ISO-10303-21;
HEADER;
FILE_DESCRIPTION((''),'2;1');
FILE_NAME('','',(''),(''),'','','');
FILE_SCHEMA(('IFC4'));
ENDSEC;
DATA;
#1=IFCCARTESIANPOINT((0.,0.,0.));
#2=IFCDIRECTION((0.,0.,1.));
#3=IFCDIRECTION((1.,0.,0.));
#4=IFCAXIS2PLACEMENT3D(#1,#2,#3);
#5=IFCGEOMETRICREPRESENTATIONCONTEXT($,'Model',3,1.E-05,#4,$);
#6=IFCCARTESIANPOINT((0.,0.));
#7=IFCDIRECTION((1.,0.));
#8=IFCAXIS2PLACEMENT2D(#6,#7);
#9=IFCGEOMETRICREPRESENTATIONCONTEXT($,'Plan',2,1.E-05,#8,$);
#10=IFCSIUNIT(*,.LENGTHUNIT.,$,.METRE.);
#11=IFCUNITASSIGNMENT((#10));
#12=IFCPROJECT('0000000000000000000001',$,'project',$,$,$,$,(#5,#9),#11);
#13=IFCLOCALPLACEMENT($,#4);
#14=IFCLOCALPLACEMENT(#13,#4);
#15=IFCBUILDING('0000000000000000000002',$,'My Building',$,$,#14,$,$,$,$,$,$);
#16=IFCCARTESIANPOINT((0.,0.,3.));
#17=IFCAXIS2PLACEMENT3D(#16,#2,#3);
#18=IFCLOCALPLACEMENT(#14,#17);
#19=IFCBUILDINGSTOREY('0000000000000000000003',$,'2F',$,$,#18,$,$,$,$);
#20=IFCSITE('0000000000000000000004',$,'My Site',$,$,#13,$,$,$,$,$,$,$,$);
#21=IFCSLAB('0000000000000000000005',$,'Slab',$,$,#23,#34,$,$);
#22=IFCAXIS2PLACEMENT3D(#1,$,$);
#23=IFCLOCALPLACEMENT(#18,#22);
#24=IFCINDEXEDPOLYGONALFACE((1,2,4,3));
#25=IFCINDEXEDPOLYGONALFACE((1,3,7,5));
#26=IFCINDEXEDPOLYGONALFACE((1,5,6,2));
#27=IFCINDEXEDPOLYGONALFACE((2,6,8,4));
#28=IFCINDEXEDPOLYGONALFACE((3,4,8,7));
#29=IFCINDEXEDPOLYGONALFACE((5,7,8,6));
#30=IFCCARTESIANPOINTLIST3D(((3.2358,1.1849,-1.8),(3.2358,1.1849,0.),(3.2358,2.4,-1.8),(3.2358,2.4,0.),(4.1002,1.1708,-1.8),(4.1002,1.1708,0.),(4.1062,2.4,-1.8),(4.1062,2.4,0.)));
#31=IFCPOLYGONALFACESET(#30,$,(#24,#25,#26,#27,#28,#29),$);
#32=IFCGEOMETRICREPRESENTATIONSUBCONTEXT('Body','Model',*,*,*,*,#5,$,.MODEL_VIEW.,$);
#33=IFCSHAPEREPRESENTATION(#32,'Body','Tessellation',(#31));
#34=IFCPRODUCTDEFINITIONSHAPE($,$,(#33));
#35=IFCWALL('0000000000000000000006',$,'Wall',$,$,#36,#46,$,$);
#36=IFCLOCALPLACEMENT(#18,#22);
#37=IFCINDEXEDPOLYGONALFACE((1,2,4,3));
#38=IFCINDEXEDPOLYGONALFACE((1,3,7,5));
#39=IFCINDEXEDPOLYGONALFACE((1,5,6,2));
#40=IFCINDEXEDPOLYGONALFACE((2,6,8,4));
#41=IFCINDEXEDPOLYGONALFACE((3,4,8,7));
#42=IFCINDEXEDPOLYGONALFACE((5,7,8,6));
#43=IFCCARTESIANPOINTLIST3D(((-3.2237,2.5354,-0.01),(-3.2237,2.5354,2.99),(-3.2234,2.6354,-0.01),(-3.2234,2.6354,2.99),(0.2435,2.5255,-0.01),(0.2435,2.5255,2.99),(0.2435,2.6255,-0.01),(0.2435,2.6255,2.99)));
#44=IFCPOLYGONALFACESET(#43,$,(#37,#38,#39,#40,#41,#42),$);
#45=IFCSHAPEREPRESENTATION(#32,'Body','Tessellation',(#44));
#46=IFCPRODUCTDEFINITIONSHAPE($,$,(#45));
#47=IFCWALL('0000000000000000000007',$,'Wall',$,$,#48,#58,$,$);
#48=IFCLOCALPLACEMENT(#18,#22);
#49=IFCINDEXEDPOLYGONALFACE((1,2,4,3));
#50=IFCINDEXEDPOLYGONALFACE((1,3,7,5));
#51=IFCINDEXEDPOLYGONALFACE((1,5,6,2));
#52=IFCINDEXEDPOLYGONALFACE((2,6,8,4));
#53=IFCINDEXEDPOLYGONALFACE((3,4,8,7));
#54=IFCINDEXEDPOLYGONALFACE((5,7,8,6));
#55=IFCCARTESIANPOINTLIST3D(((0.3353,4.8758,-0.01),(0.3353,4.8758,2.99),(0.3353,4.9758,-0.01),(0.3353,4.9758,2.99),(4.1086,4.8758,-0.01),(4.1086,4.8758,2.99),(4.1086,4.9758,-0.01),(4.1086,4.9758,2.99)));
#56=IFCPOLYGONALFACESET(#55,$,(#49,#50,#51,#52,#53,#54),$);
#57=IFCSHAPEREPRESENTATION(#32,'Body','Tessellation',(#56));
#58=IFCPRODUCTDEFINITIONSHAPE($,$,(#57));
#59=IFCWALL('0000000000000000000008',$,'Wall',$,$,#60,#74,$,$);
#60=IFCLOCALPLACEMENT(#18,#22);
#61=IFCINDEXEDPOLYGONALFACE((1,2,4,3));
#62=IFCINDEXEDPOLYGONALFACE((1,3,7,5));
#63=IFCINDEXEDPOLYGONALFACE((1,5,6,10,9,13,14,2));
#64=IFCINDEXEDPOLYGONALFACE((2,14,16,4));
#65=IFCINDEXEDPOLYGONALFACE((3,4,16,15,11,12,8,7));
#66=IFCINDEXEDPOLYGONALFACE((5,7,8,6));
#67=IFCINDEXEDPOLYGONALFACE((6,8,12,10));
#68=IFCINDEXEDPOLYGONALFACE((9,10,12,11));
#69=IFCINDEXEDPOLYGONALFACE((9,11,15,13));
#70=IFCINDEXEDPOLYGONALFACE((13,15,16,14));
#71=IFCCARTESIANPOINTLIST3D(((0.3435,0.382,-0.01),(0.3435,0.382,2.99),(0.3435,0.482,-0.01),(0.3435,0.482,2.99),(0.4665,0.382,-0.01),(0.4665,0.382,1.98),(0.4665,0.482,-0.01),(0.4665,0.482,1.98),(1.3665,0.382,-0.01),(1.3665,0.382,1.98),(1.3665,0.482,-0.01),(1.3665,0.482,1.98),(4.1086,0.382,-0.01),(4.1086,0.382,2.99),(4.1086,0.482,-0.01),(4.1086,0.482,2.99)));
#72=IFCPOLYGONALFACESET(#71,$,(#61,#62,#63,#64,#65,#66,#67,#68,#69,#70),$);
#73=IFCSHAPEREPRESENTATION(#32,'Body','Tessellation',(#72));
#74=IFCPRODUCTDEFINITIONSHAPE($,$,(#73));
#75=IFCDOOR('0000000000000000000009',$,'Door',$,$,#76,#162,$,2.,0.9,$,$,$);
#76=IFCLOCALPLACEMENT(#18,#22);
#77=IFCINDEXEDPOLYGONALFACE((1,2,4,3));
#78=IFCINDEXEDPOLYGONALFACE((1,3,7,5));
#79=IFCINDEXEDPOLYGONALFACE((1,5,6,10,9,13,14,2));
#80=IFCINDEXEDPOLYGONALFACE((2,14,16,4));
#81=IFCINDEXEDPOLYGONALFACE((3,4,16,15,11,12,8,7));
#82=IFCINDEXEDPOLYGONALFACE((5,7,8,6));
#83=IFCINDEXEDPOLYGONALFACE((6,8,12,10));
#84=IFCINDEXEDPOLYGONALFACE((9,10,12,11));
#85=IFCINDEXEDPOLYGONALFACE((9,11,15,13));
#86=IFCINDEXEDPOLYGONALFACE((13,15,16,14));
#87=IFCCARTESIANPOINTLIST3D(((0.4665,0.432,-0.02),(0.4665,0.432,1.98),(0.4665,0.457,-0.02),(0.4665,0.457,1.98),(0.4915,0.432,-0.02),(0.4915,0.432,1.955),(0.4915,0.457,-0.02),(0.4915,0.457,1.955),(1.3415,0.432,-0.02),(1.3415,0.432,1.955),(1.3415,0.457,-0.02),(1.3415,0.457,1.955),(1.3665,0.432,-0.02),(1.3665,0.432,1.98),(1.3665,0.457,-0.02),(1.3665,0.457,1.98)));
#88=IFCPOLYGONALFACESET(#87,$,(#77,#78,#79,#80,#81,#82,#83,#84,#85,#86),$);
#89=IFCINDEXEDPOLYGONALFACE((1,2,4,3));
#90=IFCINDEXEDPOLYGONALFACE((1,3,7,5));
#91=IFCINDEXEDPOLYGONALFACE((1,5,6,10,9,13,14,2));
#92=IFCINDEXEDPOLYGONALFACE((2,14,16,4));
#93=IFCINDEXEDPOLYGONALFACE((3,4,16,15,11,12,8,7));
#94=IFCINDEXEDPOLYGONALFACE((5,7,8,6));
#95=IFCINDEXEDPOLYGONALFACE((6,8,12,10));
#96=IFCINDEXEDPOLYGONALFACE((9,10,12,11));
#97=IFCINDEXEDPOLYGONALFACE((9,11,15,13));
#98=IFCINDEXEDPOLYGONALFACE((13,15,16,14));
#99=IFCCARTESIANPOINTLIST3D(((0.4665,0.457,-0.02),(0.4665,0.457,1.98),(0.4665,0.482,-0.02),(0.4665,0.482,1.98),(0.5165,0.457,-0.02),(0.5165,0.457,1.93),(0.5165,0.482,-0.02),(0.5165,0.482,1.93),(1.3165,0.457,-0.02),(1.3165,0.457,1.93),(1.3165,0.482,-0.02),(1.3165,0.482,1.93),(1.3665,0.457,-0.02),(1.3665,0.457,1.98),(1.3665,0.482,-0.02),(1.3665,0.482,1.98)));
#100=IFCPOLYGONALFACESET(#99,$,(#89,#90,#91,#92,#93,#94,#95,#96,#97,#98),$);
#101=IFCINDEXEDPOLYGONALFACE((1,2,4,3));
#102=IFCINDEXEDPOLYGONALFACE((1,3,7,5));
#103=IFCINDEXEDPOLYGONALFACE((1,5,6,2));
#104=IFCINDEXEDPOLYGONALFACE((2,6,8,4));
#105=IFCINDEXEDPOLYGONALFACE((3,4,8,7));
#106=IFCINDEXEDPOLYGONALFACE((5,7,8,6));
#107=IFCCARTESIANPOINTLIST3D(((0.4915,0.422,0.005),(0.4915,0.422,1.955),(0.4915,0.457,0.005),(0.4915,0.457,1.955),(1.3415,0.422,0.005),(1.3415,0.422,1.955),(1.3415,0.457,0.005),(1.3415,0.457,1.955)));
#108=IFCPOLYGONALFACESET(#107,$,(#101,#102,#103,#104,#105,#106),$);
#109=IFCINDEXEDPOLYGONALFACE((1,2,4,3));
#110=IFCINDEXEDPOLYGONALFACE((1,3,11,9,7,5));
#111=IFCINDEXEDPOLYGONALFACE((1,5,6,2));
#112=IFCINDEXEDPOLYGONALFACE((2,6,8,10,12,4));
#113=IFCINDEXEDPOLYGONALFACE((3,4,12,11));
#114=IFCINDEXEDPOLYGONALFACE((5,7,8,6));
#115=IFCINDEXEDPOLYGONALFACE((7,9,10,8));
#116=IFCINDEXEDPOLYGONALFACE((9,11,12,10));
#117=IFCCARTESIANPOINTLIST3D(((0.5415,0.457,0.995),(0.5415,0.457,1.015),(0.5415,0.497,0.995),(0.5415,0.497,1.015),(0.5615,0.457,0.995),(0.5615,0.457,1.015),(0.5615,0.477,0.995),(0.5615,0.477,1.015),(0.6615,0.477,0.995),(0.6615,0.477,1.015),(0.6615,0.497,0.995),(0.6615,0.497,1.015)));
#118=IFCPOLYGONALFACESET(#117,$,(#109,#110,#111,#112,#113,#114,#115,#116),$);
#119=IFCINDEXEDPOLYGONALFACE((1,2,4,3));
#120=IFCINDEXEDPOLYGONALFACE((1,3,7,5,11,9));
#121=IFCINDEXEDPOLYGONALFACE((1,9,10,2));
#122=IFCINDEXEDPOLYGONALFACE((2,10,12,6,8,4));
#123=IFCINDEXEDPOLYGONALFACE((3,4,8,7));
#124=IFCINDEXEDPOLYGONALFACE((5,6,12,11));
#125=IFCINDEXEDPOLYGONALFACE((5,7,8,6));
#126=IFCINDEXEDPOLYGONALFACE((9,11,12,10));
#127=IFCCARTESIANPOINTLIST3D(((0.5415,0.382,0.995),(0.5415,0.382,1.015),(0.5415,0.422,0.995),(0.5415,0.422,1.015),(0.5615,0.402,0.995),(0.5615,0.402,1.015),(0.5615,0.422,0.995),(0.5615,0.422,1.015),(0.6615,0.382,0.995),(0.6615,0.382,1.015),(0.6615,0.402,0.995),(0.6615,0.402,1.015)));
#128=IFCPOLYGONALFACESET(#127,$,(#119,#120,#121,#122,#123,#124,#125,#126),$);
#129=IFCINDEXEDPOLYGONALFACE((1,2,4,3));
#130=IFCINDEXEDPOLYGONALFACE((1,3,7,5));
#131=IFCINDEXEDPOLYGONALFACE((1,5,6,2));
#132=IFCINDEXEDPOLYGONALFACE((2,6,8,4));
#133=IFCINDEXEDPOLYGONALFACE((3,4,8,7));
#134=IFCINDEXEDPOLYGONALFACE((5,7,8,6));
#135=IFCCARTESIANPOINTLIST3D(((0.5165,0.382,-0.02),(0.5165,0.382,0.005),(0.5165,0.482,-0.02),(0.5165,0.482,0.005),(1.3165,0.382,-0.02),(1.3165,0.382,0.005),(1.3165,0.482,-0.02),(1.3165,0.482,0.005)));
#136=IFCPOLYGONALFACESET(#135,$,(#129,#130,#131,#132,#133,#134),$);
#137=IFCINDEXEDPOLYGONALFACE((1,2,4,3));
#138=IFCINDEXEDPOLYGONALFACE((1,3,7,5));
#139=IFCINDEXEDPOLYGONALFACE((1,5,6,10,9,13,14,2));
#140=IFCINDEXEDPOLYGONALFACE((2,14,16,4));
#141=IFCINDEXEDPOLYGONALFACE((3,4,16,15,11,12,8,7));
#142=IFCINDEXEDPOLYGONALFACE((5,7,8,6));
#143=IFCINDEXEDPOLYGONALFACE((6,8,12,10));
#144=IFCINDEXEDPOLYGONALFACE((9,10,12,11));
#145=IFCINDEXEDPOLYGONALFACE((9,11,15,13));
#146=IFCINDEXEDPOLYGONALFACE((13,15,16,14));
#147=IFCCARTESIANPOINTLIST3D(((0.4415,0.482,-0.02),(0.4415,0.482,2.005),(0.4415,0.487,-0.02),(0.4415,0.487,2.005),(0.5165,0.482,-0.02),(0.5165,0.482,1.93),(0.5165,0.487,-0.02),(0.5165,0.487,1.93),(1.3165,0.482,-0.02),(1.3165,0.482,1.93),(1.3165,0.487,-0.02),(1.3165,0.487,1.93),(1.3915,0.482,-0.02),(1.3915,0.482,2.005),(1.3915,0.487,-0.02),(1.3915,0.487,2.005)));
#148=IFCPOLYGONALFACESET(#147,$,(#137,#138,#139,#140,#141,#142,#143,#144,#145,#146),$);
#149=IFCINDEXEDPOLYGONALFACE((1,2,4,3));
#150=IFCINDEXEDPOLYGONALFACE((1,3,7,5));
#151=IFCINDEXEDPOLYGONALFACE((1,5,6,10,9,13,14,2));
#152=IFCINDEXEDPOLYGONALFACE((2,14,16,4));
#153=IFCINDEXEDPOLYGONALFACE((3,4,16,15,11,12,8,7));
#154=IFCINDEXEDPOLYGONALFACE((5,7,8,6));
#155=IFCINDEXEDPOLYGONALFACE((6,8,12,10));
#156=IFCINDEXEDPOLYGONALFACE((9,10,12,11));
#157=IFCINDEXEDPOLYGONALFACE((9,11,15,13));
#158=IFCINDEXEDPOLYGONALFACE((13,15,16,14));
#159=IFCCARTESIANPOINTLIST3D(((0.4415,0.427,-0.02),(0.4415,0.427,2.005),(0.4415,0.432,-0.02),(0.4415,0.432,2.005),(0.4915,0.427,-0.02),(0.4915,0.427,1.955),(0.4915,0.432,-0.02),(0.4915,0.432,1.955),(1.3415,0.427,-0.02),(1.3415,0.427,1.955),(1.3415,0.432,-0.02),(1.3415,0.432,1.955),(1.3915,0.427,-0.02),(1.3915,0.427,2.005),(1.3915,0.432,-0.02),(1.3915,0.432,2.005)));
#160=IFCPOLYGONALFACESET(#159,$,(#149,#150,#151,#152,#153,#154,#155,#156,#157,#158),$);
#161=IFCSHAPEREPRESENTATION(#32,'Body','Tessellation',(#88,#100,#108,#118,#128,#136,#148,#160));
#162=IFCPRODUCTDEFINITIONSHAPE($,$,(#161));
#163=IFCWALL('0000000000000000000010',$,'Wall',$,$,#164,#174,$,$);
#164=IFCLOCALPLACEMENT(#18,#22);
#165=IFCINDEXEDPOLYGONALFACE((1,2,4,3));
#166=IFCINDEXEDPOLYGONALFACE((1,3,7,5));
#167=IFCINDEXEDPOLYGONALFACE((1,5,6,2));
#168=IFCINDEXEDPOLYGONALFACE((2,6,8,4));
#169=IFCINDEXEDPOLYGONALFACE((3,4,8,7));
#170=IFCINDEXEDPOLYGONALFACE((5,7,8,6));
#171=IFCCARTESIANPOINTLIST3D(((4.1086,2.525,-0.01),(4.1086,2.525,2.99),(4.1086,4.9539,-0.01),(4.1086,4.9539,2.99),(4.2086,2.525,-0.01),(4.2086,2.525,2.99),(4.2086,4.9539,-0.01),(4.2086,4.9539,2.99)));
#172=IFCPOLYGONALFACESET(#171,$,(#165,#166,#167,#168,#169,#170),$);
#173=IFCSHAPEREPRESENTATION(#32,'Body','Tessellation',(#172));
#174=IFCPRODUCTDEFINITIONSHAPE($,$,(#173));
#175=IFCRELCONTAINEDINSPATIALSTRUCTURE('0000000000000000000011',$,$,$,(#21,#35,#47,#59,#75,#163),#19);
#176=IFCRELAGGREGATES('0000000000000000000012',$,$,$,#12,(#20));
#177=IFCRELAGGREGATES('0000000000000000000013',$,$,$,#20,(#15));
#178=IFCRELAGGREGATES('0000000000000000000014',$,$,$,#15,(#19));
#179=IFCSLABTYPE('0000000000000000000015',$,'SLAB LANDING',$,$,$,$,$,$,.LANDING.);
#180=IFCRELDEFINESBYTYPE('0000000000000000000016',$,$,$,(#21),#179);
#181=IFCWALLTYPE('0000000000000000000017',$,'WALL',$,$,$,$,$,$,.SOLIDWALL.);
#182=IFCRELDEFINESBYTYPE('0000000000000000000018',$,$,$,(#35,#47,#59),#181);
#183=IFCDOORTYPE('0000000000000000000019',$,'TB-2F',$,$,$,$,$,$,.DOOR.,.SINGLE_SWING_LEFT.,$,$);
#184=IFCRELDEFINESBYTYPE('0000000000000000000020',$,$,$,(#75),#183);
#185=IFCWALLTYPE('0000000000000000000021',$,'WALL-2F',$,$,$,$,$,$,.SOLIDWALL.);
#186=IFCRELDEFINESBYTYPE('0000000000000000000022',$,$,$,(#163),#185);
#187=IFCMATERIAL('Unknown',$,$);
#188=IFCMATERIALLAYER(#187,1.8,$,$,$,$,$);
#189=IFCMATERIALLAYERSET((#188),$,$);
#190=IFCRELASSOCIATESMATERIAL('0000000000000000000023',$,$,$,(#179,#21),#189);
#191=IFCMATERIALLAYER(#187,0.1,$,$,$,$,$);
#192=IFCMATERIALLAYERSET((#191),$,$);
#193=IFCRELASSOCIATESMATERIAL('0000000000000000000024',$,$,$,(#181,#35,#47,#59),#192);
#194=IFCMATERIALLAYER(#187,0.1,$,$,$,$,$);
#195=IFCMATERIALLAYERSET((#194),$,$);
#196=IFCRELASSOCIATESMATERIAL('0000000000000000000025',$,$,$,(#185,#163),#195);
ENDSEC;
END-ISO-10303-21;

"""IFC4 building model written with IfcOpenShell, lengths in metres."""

from ifc_helpers import new_model, entity, si_unit, frame, origin_with_axes, origin_2d_with_axis, place, context, subcontext, project, spatial, line, indexed_curve, outline, extrude, shape, source, transform, mapped, material, layer, layer_set, layer_usage, type_object, type_shapes, element, fill, save


model = new_model("IFC4")

# Units and contexts
model_context = context("Model", 3, precision=1e-05, world=origin_with_axes())
plan_context = context("Plan", 2, precision=1e-05, world=origin_2d_with_axis())
body_context_1 = subcontext(model_context, "Body", "Model", "MODEL_VIEW")
body_context_2 = subcontext(plan_context, "Body", "Plan", "PLAN_VIEW")
ifc_project = project(units=[si_unit("LENGTHUNIT", "METRE")], contexts=[model_context, plan_context])

# Site, building, storey
site_placement = place(None, origin_with_axes())
site = spatial("IfcSite", under=ifc_project, at=site_placement, Name="My Site")
building_placement = place(site_placement, origin_with_axes())
building = spatial("IfcBuilding", under=site, at=building_placement, Name="My Building")
storey_placement = place(building_placement, frame((0.0, 0.0, 3.0), z_axis=(0.0, 0.0, 1.0), x_axis=(1.0, 0.0, 0.0)))
storey = spatial("IfcBuildingStorey", under=building, at=storey_placement, Name="2F")

# Slab
ifc_material_1 = material(Name="Unknown")
ifc_layer_1 = layer(ifc_material_1, 1.8)
ifc_layer_set_1 = layer_set([ifc_layer_1])
ifc_layer_usage_1 = layer_usage(ifc_layer_set_1, "AXIS3", "POSITIVE", -1.8)
slab_type = type_object("IfcSlabType", Name="SLAB LANDING", PredefinedType="LANDING", material=ifc_layer_set_1)
slab_placement = place(storey_placement, frame((3.2358, 1.1849, 0.0), z_axis=(0.0, 0.0, 1.0), x_axis=(1.0, 0.0, 0.0)))
element("IfcSlab", 1, at=slab_placement, inside=storey, type_object=slab_type, material=ifc_layer_usage_1, Name="Slab", context=body_context_1, shape_type="SweptSolid", body=[
    extrude(outline(indexed_curve([(0.0, 0.0), (0.0, 1.2151), (0.8704, 1.2151), (0.8645, -0.0141), (0.0, 0.0)])), frame((0.0, 0.0, -1.8), z_axis=(0.0, 0.0, 1.0), x_axis=(1.0, 0.0, 0.0)), (0.0, 0.0, 1.0), 1.8),
])

# Shared definitions
ifc_layer_2 = layer(ifc_material_1, 0.1)
ifc_layer_set_2 = layer_set([ifc_layer_2])
wall_type_1 = type_object("IfcWallType", Name="WALL", PredefinedType="SOLIDWALL", material=ifc_layer_set_2)

# Walls
ifc_layer_usage_2 = layer_usage(ifc_layer_set_2, "AXIS2", "POSITIVE", 0.0)
wall_1_placement = place(storey_placement, frame((-3.2237, 2.5354, -0.01), z_axis=(0.0, 0.0, 1.0), x_axis=(0.999996, -0.002859, 0.0)))
element("IfcWall", 2, at=wall_1_placement, inside=storey, type_object=wall_type_1, material=ifc_layer_usage_2, Name="Wall", context=body_context_1, shape_type="SweptSolid", body=[
    extrude(outline(indexed_curve([(0.0, 0.0), (0.0, 0.1), (3.4669, 0.1), (3.4672, 0.0)], segments=[line(1, 2, 3, 4, 1)])), origin_with_axes(), (0.0, 0.0, 1.0), 3.0),
])
ifc_layer_usage_3 = layer_usage(ifc_layer_set_2, "AXIS2", "POSITIVE", 0.0)
wall_2_placement = place(storey_placement, frame((0.3353, 4.8758, -0.01), z_axis=(0.0, 0.0, 1.0), x_axis=(1.0, 0.0, 0.0)))
element("IfcWall", 3, at=wall_2_placement, inside=storey, type_object=wall_type_1, material=ifc_layer_usage_3, Name="Wall", context=body_context_1, shape_type="SweptSolid", body=[
    extrude(outline(indexed_curve([(0.0, 0.0), (0.0, 0.1), (3.7733, 0.1), (3.7733, 0.0)], segments=[line(1, 2, 3, 4, 1)])), origin_with_axes(), (0.0, 0.0, 1.0), 3.0),
])

# Wall, opening, door
ifc_layer_usage_4 = layer_usage(ifc_layer_set_2, "AXIS2", "POSITIVE", 0.0)
wall_3_placement = place(storey_placement, frame((0.3435, 0.382, -0.01), z_axis=(0.0, 0.0, 1.0), x_axis=(1.0, 0.0, 0.0)))
wall_3 = element("IfcWall", 4, at=wall_3_placement, inside=storey, type_object=wall_type_1, material=ifc_layer_usage_4, Name="Wall", context=body_context_1, shape_type="SweptSolid", body=[
    extrude(outline(indexed_curve([(0.0, 0.0), (0.0, 0.1), (3.7651, 0.1), (3.7651, 0.0)], segments=[line(1, 2, 3, 4, 1)])), origin_with_axes(), (0.0, 0.0, 1.0), 3.0),
])
shared_shape_1 = source(origin_with_axes(), body_context_1, "Body", "SweptSolid", [
    extrude(outline(indexed_curve([(0.0, 0.0), (0.9, 0.0), (0.9, 2.0), (0.0, 2.0)], segments=[line(1, 2, 3, 4, 1)])), frame((0.0, -0.6, 0.0), z_axis=(0.0, -1.0, 0.0), x_axis=(1.0, 0.0, 0.0)), (0.0, 0.0, -1.0), 1.2),
])
opening_1_placement = place(wall_3_placement, frame((1.023, 0.1, -0.01), z_axis=(0.0, 0.0, 1.0), x_axis=(-1.0, 0.0, 0.0)))
opening_1 = element("IfcOpeningElement", 5, at=opening_1_placement, cuts=wall_3, PredefinedType="OPENING", context=body_context_1, shape_type="MappedRepresentation", body=[
    mapped(shared_shape_1, transform((0.0, 0.0, 0.0), x_axis=(1.0, 0.0, 0.0), y_axis=(0.0, 1.0, 0.0), z_axis=(0.0, 0.0, 1.0), scale=1.0)),
])
door_type_1 = type_object("IfcDoorType", Name="TB-2F", OperationType="SINGLE_SWING_LEFT", PredefinedType="DOOR")
shared_shape_2 = source(origin_with_axes(), body_context_1, "Body", "SweptSolid", [
    extrude(outline(indexed_curve([(0.0, 0.0), (0.0, 2.0), (0.9, 2.0), (0.9, 0.0), (0.875, 0.0), (0.875, 1.975), (0.025, 1.975), (0.025, 0.0)], segments=[line(1, 2, 3, 4, 5, 6, 7, 8, 1)])), frame((0.0, 0.025, 0.0), z_axis=(0.0, -1.0, 0.0), x_axis=(1.0, 0.0, 0.0)), (0.0, 0.0, -1.0), 0.025),
    extrude(outline(indexed_curve([(0.0, 0.0), (0.0, 2.0), (0.9, 2.0), (0.9, 0.0), (0.85, 0.0), (0.85, 1.95), (0.05, 1.95), (0.05, 0.0)], segments=[line(1, 2, 3, 4, 5, 6, 7, 8, 1)])), frame((0.0, 0.0, 0.0), z_axis=(0.0, -1.0, 0.0), x_axis=(1.0, 0.0, 0.0)), (0.0, 0.0, -1.0), 0.025),
    extrude(outline(indexed_curve([(0.0, 0.0), (0.85, 0.0), (0.85, 0.035), (0.0, 0.035)], segments=[line(1, 2, 3, 4, 1)])), frame((0.025, 0.025, 0.025), z_axis=(0.0, 0.0, 1.0), x_axis=(1.0, 0.0, 0.0)), (0.0, 0.0, 1.0), 1.95),
    extrude(outline(indexed_curve([(0.0, 0.0), (0.0, -0.04), (-0.12, -0.04), (-0.12, -0.02), (-0.02, -0.02), (-0.02, 0.0)], segments=[line(1, 2, 3, 4, 5, 6, 1)])), frame((0.825, 0.025, 1.015), z_axis=(0.0, 0.0, 1.0), x_axis=(1.0, 0.0, 0.0)), (0.0, 0.0, 1.0), 0.02),
    extrude(outline(indexed_curve([(0.0, 0.0), (0.0, 0.04), (-0.12, 0.04), (-0.12, 0.02), (-0.02, 0.02), (-0.02, 0.0)], segments=[line(1, 2, 3, 4, 5, 6, 1)])), frame((0.825, 0.06, 1.015), z_axis=(0.0, 0.0, 1.0), x_axis=(1.0, 0.0, 0.0)), (0.0, 0.0, 1.0), 0.02),
    extrude(outline(indexed_curve([(0.0, 0.0), (0.8, 0.0), (0.8, 0.1), (0.0, 0.1)], segments=[line(1, 2, 3, 4, 1)])), frame((0.05, 0.0, 0.0), z_axis=(0.0, 0.0, 1.0), x_axis=(1.0, 0.0, 0.0)), (0.0, 0.0, 1.0), 0.025),
    extrude(outline(indexed_curve([(0.0, 0.0), (0.0, 2.025), (0.95, 2.025), (0.95, 0.0), (0.875, 0.0), (0.875, 1.95), (0.075, 1.95), (0.075, 0.0)], segments=[line(1, 2, 3, 4, 5, 6, 7, 8, 1)])), frame((-0.025, -0.005, 0.0), z_axis=(0.0, -1.0, 0.0), x_axis=(1.0, 0.0, 0.0)), (0.0, 0.0, -1.0), 0.005),
    extrude(outline(indexed_curve([(0.0, 0.0), (0.0, 2.025), (0.95, 2.025), (0.95, 0.0), (0.9, 0.0), (0.9, 1.975), (0.05, 1.975), (0.05, 0.0)], segments=[line(1, 2, 3, 4, 5, 6, 7, 8, 1)])), frame((-0.025, 0.05, 0.0), z_axis=(0.0, -1.0, 0.0), x_axis=(1.0, 0.0, 0.0)), (0.0, 0.0, -1.0), 0.005),
])
shared_shape_3 = source(origin_with_axes(), body_context_2, "Body", "Curve2D", [
    entity("IfcIndexedPolyCurve", entity("IfcCartesianPointList2D", [[0.0, 0.0], [0.0, 0.05], [0.025, 0.05], [0.025, 0.025], [0.05, 0.025], [0.05, 0.0]]), [entity("IfcLineIndex", [1, 2, 3, 4, 5, 6, 1])]),
    entity("IfcIndexedPolyCurve", entity("IfcCartesianPointList2D", [[0.9, 0.0], [0.9, 0.05], [0.875, 0.05], [0.875, 0.025], [0.85, 0.025], [0.85, 0.0]]), [entity("IfcLineIndex", [1, 2, 3, 4, 5, 6, 1])]),
    entity("IfcTrimmedCurve", entity("IfcEllipse", entity("IfcAxis2Placement2D", entity("IfcCartesianPoint", [0.06, 0.05]), entity("IfcDirection", [1.0, 0.0])), 0.815, 0.85), [entity("IfcCartesianPoint", [0.875, 0.05])], [entity("IfcCartesianPoint", [0.06, 0.9])], True, "CARTESIAN"),
    entity("IfcIndexedPolyCurve", entity("IfcCartesianPointList2D", [[0.025, 0.05], [0.06, 0.05], [0.06, 0.9], [0.025, 0.9]]), [entity("IfcLineIndex", [1, 2, 3, 4, 1])]),
])
type_shapes(door_type_1, [shared_shape_2, shared_shape_3])
door_1_placement = place(opening_1_placement, frame((0.0, 0.0, 0.0), z_axis=(0.0, 0.0, 1.0), x_axis=(1.0, 0.0, 0.0)))
door_1 = element("IfcDoor", 6, at=door_1_placement, inside=storey, type_object=door_type_1, Name="Door", OverallHeight=2.0, OverallWidth=0.9, shapes=[
    shape(body_context_1, "Body", "MappedRepresentation", [mapped(shared_shape_2, transform((0.0, 0.0, 0.0), x_axis=(1.0, 0.0, 0.0), y_axis=(0.0, 1.0, 0.0), z_axis=(0.0, 0.0, 1.0), scale=1.0))]),
    shape(body_context_2, "Body", "MappedRepresentation", [mapped(shared_shape_3, transform((0.0, 0.0, 0.0), x_axis=(1.0, 0.0, 0.0), y_axis=(0.0, 1.0, 0.0), z_axis=(0.0, 0.0, 1.0), scale=1.0))]),
])
fill(opening_1, door_1)

# Wall
ifc_layer_3 = layer(ifc_material_1, 0.1)
ifc_layer_set_3 = layer_set([ifc_layer_3])
ifc_layer_usage_5 = layer_usage(ifc_layer_set_3, "AXIS2", "POSITIVE", 0.0)
wall_type_2 = type_object("IfcWallType", Name="WALL-2F", PredefinedType="SOLIDWALL", material=ifc_layer_set_3)
wall_4_placement = place(storey_placement, frame((4.2086, 2.525, -0.01), z_axis=(0.0, 0.0, 1.0), x_axis=(0.0, 1.0, 0.0)))
element("IfcWall", 7, at=wall_4_placement, inside=storey, type_object=wall_type_2, material=ifc_layer_usage_5, Name="Wall", context=body_context_1, shape_type="SweptSolid", body=[
    extrude(outline(indexed_curve([(0.0, 0.0), (0.0, 0.1), (2.4288, 0.1), (2.4288, 0.0)], segments=[line(1, 2, 3, 4, 1)])), origin_with_axes(), (0.0, 0.0, 1.0), 3.0),
])

save(model, "model.ifc")
